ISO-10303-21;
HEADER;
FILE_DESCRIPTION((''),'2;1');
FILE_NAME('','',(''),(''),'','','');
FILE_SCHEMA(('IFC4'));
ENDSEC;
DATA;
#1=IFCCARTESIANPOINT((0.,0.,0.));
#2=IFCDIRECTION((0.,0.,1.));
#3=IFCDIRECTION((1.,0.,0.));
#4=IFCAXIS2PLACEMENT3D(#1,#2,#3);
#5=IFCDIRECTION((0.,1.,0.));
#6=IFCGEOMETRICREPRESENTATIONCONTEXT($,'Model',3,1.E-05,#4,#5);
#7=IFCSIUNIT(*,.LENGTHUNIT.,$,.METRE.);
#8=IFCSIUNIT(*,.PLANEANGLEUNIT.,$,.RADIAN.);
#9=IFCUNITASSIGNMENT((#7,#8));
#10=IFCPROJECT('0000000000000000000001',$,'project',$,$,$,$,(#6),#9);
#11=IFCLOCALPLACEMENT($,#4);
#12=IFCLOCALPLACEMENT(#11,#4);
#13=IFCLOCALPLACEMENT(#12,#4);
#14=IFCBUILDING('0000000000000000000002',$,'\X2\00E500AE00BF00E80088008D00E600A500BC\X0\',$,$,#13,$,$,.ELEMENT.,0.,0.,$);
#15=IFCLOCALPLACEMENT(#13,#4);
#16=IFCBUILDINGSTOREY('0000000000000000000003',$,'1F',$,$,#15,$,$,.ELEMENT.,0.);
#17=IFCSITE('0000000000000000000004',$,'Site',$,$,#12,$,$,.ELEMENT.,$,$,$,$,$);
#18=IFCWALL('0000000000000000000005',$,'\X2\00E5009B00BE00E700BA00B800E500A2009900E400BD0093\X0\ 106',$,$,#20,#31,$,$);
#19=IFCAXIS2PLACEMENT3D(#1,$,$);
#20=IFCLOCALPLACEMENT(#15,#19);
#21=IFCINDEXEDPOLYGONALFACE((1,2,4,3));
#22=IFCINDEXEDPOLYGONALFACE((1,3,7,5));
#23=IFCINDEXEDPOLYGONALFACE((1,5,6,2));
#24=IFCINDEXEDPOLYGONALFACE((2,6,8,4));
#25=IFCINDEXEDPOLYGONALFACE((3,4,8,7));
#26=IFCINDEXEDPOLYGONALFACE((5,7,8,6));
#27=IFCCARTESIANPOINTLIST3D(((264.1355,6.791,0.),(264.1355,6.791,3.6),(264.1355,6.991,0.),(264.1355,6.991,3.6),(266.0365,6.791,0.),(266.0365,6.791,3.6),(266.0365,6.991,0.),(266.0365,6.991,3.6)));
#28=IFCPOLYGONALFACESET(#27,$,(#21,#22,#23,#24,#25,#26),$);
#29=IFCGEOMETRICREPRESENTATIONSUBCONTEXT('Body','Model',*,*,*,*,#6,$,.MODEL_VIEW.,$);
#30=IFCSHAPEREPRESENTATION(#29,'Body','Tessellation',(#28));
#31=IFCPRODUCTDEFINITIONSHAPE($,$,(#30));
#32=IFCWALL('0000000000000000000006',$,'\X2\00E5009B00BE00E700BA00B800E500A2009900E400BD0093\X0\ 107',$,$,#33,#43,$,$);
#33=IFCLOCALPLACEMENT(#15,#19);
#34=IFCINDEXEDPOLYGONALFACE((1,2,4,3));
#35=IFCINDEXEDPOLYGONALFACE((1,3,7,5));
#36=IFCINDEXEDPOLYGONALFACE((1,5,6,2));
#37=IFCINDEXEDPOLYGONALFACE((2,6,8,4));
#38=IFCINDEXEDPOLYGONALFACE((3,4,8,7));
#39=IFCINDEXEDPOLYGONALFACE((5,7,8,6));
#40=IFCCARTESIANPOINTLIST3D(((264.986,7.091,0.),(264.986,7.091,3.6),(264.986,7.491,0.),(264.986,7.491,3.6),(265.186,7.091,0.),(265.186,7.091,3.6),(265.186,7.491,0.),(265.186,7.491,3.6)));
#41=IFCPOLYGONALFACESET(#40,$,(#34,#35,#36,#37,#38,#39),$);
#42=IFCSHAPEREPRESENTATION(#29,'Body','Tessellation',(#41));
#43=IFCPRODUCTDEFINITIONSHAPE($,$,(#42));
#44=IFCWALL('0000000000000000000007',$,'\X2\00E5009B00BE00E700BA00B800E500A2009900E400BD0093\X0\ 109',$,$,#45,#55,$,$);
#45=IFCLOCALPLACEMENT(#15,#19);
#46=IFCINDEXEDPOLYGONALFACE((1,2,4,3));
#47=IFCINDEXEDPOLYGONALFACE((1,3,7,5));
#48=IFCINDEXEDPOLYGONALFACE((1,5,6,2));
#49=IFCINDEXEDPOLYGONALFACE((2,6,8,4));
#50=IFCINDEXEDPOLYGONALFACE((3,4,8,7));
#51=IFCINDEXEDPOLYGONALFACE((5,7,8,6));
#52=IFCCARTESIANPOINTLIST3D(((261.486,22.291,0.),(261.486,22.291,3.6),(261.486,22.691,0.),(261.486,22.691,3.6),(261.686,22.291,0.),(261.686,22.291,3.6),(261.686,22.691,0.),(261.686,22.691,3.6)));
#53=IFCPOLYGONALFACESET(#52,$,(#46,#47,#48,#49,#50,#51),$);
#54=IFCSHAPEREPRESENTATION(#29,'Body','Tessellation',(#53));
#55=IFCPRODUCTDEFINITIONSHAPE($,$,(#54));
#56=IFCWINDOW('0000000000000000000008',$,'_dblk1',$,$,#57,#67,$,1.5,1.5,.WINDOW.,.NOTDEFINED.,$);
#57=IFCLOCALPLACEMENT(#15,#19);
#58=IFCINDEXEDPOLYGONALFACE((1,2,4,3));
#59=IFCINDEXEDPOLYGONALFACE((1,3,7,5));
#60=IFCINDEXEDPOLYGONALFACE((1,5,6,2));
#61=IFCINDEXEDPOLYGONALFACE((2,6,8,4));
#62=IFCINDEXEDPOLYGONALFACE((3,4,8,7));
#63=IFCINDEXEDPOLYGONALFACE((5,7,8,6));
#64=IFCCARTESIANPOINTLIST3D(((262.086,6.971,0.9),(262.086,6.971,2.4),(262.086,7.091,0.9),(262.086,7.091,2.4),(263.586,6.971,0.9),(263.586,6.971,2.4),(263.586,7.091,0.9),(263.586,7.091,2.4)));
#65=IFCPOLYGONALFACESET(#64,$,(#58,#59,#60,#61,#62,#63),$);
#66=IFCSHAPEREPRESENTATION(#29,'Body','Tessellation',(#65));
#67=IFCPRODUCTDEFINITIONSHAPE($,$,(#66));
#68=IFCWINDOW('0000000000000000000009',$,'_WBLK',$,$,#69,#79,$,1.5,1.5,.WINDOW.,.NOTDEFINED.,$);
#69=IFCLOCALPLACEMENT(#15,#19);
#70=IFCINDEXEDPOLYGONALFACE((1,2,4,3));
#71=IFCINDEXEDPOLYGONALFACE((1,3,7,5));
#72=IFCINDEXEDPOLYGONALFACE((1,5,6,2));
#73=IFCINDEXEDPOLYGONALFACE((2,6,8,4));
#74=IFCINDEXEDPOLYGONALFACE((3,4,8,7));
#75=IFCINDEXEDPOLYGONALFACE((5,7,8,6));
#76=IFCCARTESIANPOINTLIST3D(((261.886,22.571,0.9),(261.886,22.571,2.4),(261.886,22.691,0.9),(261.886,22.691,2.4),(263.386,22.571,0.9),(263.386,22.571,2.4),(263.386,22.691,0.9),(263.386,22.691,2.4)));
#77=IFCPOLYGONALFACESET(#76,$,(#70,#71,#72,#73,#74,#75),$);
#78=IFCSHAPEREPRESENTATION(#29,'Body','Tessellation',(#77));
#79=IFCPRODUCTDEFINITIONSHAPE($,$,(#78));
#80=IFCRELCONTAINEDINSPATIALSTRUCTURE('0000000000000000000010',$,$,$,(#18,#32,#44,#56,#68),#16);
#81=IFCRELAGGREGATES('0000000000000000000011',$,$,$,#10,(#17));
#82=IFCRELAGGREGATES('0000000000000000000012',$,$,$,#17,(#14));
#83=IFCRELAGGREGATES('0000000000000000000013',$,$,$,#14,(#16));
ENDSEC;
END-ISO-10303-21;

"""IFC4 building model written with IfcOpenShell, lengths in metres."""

from ifc_helpers import new_model, si_unit, direction, frame, frame_2d, origin_with_axes, place, context, subcontext, project, spatial, rectangle, extrude, element, save


model = new_model("IFC4")

# Units and contexts
model_context = context("Model", 3, precision=1e-05, world=origin_with_axes(), true_north=direction((0.0, 1.0, 0.0)))
body_context = subcontext(model_context, "Body", "Model", "MODEL_VIEW")
ifc_project = project(units=[si_unit("LENGTHUNIT", "METRE"), si_unit("PLANEANGLEUNIT", "RADIAN")], contexts=[model_context])

# Site, building, storey
placement = place(None, origin_with_axes())
site_placement = place(placement, origin_with_axes())
site = spatial("IfcSite", under=ifc_project, at=site_placement, Name="Site", CompositionType="ELEMENT")
building_placement = place(site_placement, origin_with_axes())
building = spatial("IfcBuilding", under=site, at=building_placement, Name="å®¿è\u0088\u008dæ¥¼", CompositionType="ELEMENT", ElevationOfRefHeight=0.0, ElevationOfTerrain=0.0)
storey_placement = place(building_placement, origin_with_axes())
storey = spatial("IfcBuildingStorey", under=building, at=storey_placement, Name="1F", CompositionType="ELEMENT", Elevation=0.0)

# Walls
wall_1_placement = place(storey_placement, frame((265.086, 6.891, 0.0), z_axis=(0.0, 0.0, 1.0), x_axis=(1.0, 0.0, 0.0)))
element("IfcWall", 1, at=wall_1_placement, inside=storey, Name="å\u009b¾çº¸å¢\u0099ä½\u0093 106", context=body_context, shape_type="SweptSolid", body=[
    extrude(rectangle(XDim=1.901, YDim=0.2, at=frame_2d((0.0, 0.0), x_axis=(1.0, 0.0, 0.0))), frame((0.0, 0.0, 0.0), z_axis=(0.0, 0.0, 1.0)), (0.0, 0.0, 1.0), 3.6),
])
for number, where, z_axis, x_axis, name in (
    (2, (265.086, 7.291, 0.0), (0.0, 0.0, 1.0), (0.0, -1.0, 0.0), "å\u009b¾çº¸å¢\u0099ä½\u0093 107"),
    (3, (261.586, 22.491, 0.0), (0.0, 0.0, 1.0), (0.0, 1.0, 0.0), "å\u009b¾çº¸å¢\u0099ä½\u0093 109"),
):
    element("IfcWall", number, at=place(storey_placement, frame(where, z_axis=z_axis, x_axis=x_axis)), inside=storey, Name=name, context=body_context, shape_type="SweptSolid", body=[
        extrude(rectangle(XDim=0.4, YDim=0.2, at=frame_2d((0.0, 0.0), x_axis=(1.0, 0.0, 0.0))), frame((0.0, 0.0, 0.0), z_axis=(0.0, 0.0, 1.0)), (0.0, 0.0, 1.0), 3.6),
    ])

# Windows
for number, where, z_axis, x_axis, name in (
    (4, (262.836, 7.031, 0.9), (0.0, 0.0, 1.0), (1.0, 0.0, 0.0), "_dblk1"),
    (5, (262.636, 22.631, 0.9), (0.0, 0.0, 1.0), (1.0, 0.0, 0.0), "_WBLK"),
):
    element("IfcWindow", number, at=place(storey_placement, frame(where, z_axis=z_axis, x_axis=x_axis)), inside=storey, Name=name, OverallHeight=1.5, OverallWidth=1.5, PartitioningType="NOTDEFINED", PredefinedType="WINDOW", context=body_context, shape_type="SweptSolid", body=[
        extrude(rectangle(XDim=1.5, YDim=0.12, at=frame_2d((0.0, 0.0), x_axis=(1.0, 0.0, 0.0))), frame((0.0, 0.0, 0.0), z_axis=(0.0, 0.0, 1.0)), (0.0, 0.0, 1.0), 1.5),
    ])

save(model, "model.ifc")
